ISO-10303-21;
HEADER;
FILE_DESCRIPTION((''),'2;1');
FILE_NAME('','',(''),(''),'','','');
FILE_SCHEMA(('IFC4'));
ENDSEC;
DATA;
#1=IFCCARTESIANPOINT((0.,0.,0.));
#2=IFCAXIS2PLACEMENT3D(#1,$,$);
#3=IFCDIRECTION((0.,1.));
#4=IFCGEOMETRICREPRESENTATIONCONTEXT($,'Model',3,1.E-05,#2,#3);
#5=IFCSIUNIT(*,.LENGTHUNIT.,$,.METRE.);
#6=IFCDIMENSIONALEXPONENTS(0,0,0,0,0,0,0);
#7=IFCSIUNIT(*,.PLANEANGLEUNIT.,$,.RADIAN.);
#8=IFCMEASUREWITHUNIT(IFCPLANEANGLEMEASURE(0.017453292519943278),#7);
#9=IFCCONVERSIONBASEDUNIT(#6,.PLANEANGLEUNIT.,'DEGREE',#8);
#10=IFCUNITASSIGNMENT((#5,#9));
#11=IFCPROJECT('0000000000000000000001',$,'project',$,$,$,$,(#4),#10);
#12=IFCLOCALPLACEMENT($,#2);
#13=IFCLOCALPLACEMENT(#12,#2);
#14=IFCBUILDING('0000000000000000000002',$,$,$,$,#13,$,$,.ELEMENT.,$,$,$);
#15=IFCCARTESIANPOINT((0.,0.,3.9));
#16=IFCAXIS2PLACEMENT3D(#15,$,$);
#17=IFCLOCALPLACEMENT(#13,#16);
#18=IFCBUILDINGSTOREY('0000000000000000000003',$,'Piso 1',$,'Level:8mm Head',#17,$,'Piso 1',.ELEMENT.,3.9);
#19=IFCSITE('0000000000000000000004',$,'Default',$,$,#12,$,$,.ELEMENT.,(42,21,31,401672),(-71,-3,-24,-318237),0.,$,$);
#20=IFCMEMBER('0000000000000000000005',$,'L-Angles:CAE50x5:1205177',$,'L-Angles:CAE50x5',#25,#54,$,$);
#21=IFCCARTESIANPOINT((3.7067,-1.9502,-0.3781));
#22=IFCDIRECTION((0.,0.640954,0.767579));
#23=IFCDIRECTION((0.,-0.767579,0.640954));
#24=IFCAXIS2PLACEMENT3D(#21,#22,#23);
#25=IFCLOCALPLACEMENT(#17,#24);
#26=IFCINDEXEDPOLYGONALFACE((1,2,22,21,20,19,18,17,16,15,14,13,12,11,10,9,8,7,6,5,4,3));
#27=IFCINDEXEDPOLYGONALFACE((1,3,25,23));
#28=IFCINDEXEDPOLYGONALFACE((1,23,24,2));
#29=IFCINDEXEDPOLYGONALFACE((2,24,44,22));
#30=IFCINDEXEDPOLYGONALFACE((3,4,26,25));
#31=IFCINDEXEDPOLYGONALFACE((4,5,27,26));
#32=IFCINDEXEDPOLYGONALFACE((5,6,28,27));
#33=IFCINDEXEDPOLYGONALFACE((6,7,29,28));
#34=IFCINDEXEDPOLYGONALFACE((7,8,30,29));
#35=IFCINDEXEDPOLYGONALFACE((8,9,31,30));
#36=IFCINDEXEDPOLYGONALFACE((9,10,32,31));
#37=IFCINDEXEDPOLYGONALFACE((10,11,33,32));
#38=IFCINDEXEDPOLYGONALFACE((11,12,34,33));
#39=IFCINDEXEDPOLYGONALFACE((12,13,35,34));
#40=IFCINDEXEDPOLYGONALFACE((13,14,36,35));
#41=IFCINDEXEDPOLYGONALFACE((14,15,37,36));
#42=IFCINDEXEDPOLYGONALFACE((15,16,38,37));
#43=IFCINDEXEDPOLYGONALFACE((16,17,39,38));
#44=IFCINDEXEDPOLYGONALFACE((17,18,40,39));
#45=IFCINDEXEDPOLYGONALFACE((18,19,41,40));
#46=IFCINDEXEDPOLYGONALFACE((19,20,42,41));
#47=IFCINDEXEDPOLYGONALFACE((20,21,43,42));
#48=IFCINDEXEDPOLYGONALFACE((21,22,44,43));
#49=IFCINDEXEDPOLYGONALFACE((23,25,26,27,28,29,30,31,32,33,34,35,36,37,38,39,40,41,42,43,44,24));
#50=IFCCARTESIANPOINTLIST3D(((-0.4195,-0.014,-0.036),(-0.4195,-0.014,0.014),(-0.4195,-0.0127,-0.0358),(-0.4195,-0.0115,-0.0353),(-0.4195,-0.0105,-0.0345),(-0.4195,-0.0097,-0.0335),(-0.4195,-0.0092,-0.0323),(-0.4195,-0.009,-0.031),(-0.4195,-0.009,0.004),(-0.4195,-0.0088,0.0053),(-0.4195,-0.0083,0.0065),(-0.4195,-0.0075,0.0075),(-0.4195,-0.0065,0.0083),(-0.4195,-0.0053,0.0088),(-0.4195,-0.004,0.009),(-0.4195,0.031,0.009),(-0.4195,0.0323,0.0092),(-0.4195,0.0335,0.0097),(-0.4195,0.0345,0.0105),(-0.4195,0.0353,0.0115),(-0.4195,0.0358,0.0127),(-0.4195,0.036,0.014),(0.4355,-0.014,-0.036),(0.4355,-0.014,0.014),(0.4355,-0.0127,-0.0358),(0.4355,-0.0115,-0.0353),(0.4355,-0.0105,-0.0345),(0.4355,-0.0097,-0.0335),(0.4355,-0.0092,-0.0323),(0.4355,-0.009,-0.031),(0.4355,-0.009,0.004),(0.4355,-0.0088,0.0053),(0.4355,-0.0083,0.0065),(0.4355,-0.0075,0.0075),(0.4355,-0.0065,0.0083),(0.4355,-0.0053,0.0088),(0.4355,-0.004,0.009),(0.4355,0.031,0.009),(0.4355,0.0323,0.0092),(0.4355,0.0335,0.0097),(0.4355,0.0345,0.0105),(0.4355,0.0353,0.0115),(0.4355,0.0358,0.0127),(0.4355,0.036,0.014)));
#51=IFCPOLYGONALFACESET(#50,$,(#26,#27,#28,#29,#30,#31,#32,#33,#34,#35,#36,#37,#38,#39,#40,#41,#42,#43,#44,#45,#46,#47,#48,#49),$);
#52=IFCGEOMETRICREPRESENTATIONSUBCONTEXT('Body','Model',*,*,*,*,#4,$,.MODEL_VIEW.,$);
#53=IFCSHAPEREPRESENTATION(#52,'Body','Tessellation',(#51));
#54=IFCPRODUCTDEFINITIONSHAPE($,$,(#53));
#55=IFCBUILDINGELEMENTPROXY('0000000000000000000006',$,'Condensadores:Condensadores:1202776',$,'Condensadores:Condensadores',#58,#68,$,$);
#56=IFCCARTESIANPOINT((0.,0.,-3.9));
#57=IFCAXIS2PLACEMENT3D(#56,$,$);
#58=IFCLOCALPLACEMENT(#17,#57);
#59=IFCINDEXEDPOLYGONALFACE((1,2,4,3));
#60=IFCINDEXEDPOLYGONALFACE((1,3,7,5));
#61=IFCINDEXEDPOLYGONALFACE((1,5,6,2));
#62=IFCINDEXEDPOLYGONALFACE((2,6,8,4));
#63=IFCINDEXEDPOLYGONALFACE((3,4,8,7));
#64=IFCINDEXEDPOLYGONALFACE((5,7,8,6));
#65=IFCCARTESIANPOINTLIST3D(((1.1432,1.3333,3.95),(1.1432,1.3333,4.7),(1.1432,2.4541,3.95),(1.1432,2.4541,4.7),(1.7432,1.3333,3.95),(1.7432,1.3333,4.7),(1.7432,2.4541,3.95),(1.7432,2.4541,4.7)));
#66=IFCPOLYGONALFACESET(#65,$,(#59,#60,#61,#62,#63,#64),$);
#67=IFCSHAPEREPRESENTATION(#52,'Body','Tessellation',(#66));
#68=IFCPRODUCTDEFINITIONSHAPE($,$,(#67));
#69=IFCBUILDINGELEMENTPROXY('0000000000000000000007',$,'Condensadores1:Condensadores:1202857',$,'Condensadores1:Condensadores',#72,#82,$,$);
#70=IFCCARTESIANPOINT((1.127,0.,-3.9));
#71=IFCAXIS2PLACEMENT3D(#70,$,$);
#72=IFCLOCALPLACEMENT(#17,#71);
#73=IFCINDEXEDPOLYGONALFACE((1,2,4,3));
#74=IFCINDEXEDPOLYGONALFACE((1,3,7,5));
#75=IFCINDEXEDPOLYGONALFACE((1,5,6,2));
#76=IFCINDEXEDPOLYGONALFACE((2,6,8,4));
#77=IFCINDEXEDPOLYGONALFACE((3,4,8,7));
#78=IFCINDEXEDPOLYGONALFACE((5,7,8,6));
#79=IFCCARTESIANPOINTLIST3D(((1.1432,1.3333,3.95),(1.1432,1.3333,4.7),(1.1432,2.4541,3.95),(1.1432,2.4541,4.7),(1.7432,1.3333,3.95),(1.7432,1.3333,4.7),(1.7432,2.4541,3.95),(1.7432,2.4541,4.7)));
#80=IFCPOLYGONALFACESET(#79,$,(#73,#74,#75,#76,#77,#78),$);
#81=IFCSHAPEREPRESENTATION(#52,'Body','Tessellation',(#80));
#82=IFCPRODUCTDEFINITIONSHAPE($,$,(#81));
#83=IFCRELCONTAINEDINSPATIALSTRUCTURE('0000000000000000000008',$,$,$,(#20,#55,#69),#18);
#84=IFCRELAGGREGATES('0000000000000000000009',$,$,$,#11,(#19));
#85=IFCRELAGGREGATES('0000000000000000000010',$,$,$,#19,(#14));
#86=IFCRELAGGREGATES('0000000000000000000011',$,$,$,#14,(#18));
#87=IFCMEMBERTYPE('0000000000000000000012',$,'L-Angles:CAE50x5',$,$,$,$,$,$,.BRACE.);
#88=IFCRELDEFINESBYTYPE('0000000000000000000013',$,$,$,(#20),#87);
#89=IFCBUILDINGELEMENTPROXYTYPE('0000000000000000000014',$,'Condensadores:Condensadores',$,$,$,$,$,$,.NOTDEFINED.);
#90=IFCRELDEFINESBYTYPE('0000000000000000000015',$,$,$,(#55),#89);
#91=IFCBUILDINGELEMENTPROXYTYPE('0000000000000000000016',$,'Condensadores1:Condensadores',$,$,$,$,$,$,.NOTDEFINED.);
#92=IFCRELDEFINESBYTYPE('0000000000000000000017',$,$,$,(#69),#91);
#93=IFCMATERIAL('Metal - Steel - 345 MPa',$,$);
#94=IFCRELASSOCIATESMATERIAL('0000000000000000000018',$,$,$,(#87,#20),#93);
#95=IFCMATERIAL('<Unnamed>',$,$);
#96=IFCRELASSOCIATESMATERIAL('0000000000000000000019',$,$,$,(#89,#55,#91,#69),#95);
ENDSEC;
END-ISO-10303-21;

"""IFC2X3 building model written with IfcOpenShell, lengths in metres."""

from ifc_helpers import new_model, entity, si_unit, converted_unit, direction, frame, frame_2d, origin, place, context, subcontext, project, spatial, polyline, circle_curve, parameter, trimmed, segment, composite_curve, rectangle, outline, extrude, source, transform, mapped, material, type_object, type_shapes, element, save


model = new_model("IFC2X3")

# Units and contexts
model_context = context("Model", 3, precision=1e-05, world=origin(), true_north=direction((0.0, 1.0)))
body_context = subcontext(model_context, "Body", "Model", "MODEL_VIEW")
ifc_project = project(units=[si_unit("LENGTHUNIT", "METRE"), converted_unit("PLANEANGLEUNIT", "DEGREE", entity("IfcPlaneAngleMeasure", 0.017453292519943278), si_unit("PLANEANGLEUNIT", "RADIAN"), dimensions=[0, 0, 0, 0, 0, 0, 0])], contexts=[model_context])

# Site, building, storey
site_placement = place(None, origin())
site = spatial("IfcSite", under=ifc_project, at=site_placement, Name="Default", CompositionType="ELEMENT", RefLatitude=(42, 21, 31, 401672), RefLongitude=(-71, -3, -24, -318237), RefElevation=0.0)
building_placement = place(site_placement, origin())
building = spatial("IfcBuilding", under=site, at=building_placement, CompositionType="ELEMENT")
storey_placement = place(building_placement, frame((0.0, 0.0, 3.9)))
storey = spatial("IfcBuildingStorey", under=building, at=storey_placement, Name="Piso 1", ObjectType="Level:8mm Head", LongName="Piso 1", CompositionType="ELEMENT", Elevation=3.9)

# Shared definitions
ifc_material_1 = material(Name="Metal - Steel - 345 MPa")

# Member
member_type_1 = type_object("IfcMemberType", Name="L-Angles:CAE50x5", PredefinedType="BRACE", material=ifc_material_1)
shared_shape_1 = source(origin(), body_context, "Body", "SweptSolid", [
    extrude(outline(composite_curve([segment(polyline([(-0.0164, -0.0164), (0.0336, -0.0164)]), True, "CONTINUOUS"), segment(trimmed(circle_curve(frame_2d((0.0286, -0.0164), x_axis=(0.0, 1.0)), 0.005), [parameter(270.0)], [parameter(0.0)], True, "PARAMETER"), True, "CONTINUOUS"), segment(polyline([(0.0286, -0.0114), (-0.0064, -0.0114)]), True, "CONTINUOUS"), segment(trimmed(circle_curve(frame_2d((-0.0064, -0.0064), x_axis=(0.0, 1.0)), 0.005), [parameter(90.0)], [parameter(180.0)], True, "PARAMETER"), False, "CONTINUOUS"), segment(polyline([(-0.0114, -0.0064), (-0.0114, 0.0286)]), True, "CONTINUOUS"), segment(trimmed(circle_curve(frame_2d((-0.0164, 0.0286), x_axis=(0.0, 1.0)), 0.005), [parameter(270.0)], [parameter(360.0)], True, "PARAMETER"), True, "CONTINUOUS"), segment(polyline([(-0.0164, 0.0336), (-0.0164, -0.0164)]), True, "CONTINUOUS")], self_intersect=False)), frame((-0.4195, 0.0024, -0.0024), z_axis=(1.0, 0.0, 0.0), x_axis=(0.0, 0.0, -1.0)), (0.0, 0.0, 1.0), 0.855),
])
type_shapes(member_type_1, [shared_shape_1])
member_1_placement = place(storey_placement, frame((3.7067, -1.9502, -0.3781), z_axis=(0.0, 0.640954, 0.767579), x_axis=(0.0, -0.767579, 0.640954)))
element("IfcMember", 1, at=member_1_placement, inside=storey, type_object=member_type_1, material=ifc_material_1, Name="L-Angles:CAE50x5:1205177", ObjectType="L-Angles:CAE50x5", context=body_context, shape_type="MappedRepresentation", body=[
    mapped(shared_shape_1, transform((0.0, 0.0, 0.0), scale=1.0)),
])

# Building element proxies
ifc_material_2 = material(Name="<Unnamed>")
building_element_proxy_type_1 = type_object("IfcBuildingElementProxyType", Name="Condensadores:Condensadores", PredefinedType="NOTDEFINED", material=ifc_material_2)
shared_shape_2 = source(origin(), body_context, "Body", "SweptSolid", [
    extrude(rectangle(XDim=0.6, YDim=1.1208, at=frame_2d((0.0, 0.0), x_axis=(1.0, 0.0))), frame((1.4432, 1.8937, 3.95), z_axis=(0.0, 0.0, 1.0), x_axis=(-1.0, 0.0, 0.0)), (0.0, 0.0, 1.0), 0.75),
])
type_shapes(building_element_proxy_type_1, [shared_shape_2])
proxy_1_placement = place(storey_placement, frame((0.0, 0.0, -3.9)))
element("IfcBuildingElementProxy", 2, at=proxy_1_placement, inside=storey, type_object=building_element_proxy_type_1, material=ifc_material_2, Name="Condensadores:Condensadores:1202776", ObjectType="Condensadores:Condensadores", context=body_context, shape_type="MappedRepresentation", body=[
    mapped(shared_shape_2, transform((0.0, 0.0, 0.0), scale=1.0)),
])
building_element_proxy_type_2 = type_object("IfcBuildingElementProxyType", Name="Condensadores1:Condensadores", PredefinedType="NOTDEFINED", material=ifc_material_2)
shared_shape_3 = source(origin(), body_context, "Body", "SweptSolid", [
    extrude(rectangle(XDim=0.6, YDim=1.1208, at=frame_2d((0.0, 0.0), x_axis=(1.0, 0.0))), frame((1.4432, 1.8937, 3.95), z_axis=(0.0, 0.0, 1.0), x_axis=(-1.0, 0.0, 0.0)), (0.0, 0.0, 1.0), 0.75),
])
type_shapes(building_element_proxy_type_2, [shared_shape_3])
proxy_2_placement = place(storey_placement, frame((1.127, 0.0, -3.9)))
element("IfcBuildingElementProxy", 3, at=proxy_2_placement, inside=storey, type_object=building_element_proxy_type_2, material=ifc_material_2, Name="Condensadores1:Condensadores:1202857", ObjectType="Condensadores1:Condensadores", context=body_context, shape_type="MappedRepresentation", body=[
    mapped(shared_shape_3, transform((0.0, 0.0, 0.0), scale=1.0)),
])

save(model, "model.ifc")
